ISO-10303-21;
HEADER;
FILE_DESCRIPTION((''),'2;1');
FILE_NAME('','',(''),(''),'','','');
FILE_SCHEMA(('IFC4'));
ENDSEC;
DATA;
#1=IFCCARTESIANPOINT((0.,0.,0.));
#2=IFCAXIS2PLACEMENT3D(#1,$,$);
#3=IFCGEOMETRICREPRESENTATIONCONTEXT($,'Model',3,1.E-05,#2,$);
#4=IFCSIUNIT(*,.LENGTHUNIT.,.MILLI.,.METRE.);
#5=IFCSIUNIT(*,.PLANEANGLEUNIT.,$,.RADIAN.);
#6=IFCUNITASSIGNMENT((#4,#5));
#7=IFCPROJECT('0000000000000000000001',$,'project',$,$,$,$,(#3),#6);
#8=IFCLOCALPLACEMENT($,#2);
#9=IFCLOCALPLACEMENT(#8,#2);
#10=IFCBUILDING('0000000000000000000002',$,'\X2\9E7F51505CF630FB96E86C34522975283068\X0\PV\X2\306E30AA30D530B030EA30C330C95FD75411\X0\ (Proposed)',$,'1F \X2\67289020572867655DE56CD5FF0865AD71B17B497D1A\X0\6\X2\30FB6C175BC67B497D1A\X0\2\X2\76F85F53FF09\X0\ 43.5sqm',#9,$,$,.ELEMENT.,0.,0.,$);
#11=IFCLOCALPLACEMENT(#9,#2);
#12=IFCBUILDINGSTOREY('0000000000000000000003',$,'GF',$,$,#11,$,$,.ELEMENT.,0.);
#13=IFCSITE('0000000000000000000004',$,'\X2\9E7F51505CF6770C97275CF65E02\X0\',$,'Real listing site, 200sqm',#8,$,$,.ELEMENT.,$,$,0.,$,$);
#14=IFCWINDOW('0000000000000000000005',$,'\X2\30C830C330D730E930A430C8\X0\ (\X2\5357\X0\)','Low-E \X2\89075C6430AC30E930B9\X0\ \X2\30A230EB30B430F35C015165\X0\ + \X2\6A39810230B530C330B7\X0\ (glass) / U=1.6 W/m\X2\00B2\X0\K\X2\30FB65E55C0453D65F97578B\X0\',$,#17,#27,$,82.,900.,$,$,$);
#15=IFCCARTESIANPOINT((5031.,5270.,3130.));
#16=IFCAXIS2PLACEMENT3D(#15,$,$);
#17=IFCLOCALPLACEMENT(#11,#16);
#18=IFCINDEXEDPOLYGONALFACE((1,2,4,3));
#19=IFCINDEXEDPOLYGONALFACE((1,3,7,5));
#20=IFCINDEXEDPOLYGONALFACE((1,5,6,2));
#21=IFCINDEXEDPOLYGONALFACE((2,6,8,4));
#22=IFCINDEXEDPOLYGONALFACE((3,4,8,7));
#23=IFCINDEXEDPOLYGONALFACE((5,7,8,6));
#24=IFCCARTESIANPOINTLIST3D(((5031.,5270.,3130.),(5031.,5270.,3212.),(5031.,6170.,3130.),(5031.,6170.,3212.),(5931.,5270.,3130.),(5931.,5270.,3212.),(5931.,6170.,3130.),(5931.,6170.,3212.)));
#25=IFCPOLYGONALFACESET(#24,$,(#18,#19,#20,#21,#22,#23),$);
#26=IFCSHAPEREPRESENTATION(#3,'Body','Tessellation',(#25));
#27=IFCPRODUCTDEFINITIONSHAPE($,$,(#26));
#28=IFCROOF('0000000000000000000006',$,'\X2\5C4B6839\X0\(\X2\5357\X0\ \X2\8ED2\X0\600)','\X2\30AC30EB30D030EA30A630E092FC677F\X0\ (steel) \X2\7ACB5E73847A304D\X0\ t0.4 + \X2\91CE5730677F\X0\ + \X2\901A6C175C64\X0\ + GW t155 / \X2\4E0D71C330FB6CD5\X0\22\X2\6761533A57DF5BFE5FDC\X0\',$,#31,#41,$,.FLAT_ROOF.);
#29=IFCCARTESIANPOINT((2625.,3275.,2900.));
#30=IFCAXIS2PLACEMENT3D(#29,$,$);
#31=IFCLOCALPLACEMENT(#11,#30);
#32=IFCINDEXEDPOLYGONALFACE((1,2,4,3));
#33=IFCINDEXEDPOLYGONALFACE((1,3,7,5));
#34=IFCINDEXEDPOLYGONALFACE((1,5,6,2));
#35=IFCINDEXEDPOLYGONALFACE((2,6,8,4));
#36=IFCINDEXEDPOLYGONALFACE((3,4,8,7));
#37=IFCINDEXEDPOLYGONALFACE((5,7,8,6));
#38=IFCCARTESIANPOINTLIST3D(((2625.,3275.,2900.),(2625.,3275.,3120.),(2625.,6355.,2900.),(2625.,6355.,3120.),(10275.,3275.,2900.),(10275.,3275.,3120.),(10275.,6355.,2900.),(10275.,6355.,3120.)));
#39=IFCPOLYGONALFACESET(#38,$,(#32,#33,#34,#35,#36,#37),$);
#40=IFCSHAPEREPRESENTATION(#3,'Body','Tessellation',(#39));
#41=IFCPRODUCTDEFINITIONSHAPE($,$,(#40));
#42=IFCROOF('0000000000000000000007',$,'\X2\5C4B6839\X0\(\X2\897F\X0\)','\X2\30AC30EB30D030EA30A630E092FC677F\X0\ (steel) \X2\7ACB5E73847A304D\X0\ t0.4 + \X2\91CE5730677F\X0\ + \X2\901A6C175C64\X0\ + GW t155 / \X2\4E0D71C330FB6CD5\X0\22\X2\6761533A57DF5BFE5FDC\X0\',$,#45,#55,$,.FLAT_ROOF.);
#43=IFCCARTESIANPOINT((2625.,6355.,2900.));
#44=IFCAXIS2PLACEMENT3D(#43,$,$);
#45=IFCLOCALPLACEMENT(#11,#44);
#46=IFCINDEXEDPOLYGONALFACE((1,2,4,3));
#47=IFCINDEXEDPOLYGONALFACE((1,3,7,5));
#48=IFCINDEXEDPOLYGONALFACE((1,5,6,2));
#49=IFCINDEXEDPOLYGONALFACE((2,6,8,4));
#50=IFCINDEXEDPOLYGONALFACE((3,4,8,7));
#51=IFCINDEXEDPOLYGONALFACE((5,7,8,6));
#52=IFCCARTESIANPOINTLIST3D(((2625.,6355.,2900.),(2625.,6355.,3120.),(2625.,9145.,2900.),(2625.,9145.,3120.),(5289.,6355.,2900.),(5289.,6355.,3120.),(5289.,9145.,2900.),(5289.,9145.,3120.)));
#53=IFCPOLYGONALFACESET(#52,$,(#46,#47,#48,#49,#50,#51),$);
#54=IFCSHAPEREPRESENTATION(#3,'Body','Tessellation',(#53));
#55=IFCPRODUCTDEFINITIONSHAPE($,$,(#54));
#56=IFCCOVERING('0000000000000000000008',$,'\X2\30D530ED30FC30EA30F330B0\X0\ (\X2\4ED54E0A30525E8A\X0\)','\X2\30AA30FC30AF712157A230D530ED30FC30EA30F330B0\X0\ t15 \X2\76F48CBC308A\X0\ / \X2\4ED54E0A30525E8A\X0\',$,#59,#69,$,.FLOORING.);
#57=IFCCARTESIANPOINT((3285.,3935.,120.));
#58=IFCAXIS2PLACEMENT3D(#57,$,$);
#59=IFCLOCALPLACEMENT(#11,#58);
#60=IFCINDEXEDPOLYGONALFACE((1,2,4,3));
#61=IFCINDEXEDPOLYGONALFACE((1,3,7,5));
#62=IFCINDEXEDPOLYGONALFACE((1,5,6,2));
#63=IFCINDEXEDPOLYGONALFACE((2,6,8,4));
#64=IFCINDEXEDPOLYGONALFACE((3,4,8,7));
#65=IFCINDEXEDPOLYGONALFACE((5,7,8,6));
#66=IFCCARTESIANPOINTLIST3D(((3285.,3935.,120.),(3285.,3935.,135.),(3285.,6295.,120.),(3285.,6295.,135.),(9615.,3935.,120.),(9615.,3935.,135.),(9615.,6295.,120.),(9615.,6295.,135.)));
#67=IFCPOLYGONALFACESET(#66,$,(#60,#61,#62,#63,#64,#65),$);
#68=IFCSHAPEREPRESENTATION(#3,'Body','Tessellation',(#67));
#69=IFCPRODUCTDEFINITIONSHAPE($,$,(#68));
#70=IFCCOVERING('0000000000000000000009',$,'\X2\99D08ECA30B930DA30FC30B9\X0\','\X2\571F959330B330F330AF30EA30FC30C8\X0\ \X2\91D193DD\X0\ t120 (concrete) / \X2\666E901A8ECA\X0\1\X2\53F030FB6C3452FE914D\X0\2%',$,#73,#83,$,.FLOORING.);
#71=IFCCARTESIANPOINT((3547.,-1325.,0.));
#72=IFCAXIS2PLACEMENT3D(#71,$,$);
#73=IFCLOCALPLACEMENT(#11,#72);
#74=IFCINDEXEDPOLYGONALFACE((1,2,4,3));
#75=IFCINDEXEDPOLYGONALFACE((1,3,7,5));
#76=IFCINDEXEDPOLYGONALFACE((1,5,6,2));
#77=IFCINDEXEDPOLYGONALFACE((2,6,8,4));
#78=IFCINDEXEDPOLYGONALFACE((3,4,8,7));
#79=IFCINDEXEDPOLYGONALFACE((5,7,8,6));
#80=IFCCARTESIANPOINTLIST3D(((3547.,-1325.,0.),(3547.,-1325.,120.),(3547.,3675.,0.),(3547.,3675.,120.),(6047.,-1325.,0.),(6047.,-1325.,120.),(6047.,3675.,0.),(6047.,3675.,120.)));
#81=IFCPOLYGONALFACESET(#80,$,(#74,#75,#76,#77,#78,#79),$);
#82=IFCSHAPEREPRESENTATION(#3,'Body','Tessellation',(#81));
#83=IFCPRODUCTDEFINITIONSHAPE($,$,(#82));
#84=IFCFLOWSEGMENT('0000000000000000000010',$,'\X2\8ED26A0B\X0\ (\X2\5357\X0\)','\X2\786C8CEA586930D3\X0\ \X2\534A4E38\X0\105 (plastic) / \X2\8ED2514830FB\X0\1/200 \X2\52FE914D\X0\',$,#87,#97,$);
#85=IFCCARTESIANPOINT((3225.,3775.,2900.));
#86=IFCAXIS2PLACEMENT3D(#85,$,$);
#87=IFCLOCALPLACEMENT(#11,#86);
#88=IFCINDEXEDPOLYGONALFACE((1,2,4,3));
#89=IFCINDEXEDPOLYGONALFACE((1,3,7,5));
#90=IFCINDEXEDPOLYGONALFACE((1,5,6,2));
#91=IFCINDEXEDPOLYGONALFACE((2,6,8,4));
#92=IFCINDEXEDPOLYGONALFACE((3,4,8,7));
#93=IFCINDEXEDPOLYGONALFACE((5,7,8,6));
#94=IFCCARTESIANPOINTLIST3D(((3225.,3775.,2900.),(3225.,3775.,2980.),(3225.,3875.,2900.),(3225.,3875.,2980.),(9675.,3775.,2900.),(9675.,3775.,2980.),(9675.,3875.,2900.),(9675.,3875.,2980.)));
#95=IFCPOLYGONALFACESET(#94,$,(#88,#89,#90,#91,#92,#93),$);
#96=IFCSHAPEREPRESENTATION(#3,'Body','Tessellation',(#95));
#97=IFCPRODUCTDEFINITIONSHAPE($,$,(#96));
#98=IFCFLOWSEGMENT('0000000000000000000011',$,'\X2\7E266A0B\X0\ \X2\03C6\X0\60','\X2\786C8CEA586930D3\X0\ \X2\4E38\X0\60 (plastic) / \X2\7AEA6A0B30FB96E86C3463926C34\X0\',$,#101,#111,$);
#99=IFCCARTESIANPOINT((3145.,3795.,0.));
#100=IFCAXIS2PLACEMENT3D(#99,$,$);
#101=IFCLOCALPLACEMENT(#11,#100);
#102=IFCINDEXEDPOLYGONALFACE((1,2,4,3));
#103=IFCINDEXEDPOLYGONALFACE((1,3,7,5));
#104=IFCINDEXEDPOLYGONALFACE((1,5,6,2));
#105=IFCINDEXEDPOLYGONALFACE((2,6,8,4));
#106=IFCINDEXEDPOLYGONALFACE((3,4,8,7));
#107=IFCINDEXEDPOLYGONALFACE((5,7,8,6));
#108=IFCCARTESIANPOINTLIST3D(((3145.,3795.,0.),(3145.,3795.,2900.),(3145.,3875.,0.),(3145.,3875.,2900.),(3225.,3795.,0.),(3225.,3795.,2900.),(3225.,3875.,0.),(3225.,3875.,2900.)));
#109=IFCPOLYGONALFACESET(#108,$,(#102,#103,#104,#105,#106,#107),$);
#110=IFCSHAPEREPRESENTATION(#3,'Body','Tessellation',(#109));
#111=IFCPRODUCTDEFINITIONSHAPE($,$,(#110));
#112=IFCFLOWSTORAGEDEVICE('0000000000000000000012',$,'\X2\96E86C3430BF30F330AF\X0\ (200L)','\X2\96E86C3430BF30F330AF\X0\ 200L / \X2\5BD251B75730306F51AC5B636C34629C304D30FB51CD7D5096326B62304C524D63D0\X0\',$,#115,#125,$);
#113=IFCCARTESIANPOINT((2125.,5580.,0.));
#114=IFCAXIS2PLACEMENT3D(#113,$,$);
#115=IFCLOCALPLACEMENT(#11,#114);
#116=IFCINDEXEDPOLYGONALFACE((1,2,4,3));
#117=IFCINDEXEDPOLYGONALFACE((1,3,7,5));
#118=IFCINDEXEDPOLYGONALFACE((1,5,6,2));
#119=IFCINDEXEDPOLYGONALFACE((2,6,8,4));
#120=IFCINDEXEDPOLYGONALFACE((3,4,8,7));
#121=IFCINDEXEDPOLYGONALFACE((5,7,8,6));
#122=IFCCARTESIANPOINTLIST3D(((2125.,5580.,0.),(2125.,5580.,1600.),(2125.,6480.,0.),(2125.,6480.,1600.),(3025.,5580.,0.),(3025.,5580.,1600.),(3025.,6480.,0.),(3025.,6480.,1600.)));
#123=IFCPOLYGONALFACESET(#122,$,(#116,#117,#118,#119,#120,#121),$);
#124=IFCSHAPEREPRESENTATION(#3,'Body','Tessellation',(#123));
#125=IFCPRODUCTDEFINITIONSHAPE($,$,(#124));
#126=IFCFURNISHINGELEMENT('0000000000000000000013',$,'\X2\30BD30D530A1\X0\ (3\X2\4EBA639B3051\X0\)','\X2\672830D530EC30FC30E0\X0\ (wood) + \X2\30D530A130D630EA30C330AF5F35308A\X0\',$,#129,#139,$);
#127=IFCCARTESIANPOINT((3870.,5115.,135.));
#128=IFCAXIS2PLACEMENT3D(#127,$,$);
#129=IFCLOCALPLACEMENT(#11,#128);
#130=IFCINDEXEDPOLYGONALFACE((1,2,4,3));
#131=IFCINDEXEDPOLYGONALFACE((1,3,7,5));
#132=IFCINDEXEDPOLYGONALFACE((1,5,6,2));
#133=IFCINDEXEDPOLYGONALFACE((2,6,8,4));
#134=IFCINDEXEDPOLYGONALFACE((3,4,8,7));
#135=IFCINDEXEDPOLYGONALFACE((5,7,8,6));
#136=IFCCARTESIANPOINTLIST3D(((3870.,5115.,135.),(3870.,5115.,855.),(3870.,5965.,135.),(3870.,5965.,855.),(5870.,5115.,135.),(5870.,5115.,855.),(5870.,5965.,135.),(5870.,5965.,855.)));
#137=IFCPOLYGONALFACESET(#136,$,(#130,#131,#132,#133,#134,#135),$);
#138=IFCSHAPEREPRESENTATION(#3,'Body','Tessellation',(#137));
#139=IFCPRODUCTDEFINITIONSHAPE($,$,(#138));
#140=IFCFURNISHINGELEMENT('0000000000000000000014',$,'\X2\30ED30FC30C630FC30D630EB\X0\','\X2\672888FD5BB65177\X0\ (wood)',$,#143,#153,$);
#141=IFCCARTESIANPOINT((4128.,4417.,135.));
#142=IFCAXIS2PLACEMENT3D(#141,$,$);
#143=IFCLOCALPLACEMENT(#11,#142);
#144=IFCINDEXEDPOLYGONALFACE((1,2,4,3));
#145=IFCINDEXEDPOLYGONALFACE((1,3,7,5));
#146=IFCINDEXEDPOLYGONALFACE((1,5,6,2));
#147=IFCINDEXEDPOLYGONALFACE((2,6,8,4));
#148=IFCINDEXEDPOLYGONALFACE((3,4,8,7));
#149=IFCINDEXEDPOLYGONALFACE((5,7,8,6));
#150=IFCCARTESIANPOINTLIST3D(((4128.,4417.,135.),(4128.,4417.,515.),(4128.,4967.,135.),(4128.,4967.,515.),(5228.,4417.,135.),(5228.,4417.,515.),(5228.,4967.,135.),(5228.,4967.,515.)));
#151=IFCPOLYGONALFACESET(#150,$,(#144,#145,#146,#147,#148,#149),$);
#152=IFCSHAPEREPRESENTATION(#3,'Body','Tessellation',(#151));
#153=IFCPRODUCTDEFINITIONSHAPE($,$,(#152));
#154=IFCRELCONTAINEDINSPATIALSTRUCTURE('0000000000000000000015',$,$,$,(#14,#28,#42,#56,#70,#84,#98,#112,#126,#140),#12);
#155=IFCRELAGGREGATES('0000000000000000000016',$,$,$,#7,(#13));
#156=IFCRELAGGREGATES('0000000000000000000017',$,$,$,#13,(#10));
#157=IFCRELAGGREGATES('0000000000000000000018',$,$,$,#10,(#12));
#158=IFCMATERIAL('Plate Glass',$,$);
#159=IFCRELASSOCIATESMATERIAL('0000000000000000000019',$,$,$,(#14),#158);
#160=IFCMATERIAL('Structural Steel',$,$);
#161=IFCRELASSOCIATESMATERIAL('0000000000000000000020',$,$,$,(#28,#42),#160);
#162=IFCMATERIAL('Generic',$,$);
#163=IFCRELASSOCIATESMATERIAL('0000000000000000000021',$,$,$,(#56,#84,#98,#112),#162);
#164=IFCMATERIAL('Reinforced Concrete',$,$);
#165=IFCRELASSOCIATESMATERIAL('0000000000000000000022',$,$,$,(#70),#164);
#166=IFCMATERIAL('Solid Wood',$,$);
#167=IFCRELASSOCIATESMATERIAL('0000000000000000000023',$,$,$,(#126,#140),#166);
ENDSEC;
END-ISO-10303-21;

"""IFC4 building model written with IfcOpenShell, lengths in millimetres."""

from ifc_helpers import new_model, si_unit, frame, frame_2d, origin, place, context, project, spatial, rectangle, extrude, material, element, save


model = new_model("IFC4")

# Units and contexts
model_context = context("Model", 3, precision=1e-05, world=origin())
ifc_project = project(units=[si_unit("LENGTHUNIT", "METRE", prefix="MILLI"), si_unit("PLANEANGLEUNIT", "RADIAN")], contexts=[model_context])

# Site, building, storey
site_placement = place(None, origin())
site = spatial("IfcSite", under=ifc_project, at=site_placement, Name="鹿児島県霧島市", ObjectType="Real listing site, 200sqm", CompositionType="ELEMENT", RefElevation=0.0)
building_placement = place(site_placement, origin())
building = spatial("IfcBuilding", under=site, at=building_placement, Name="鹿児島・雨水利用とPVのオフグリッド志向 (Proposed)", ObjectType="1F 木造在来工法（断熱等級6・気密等級2相当） 43.5sqm", CompositionType="ELEMENT", ElevationOfRefHeight=0.0, ElevationOfTerrain=0.0)
storey_placement = place(building_placement, origin())
storey = spatial("IfcBuildingStorey", under=building, at=storey_placement, Name="GF", CompositionType="ELEMENT", Elevation=0.0)

# Shared definitions
ifc_material_1 = material(Name="Solid Wood")

# Shared definitions
ifc_material_2 = material(Name="Reinforced Concrete")

# Shared definitions
ifc_material_3 = material(Name="Plate Glass")

# Window
window_1_placement = place(storey_placement, frame((5031.0, 5270.0, 3130.0)))
element("IfcWindow", 1, at=window_1_placement, inside=storey, material=ifc_material_3, Name="トップライト (南)", Description="Low-E 複層ガラス アルゴン封入 + 樹脂サッシ (glass) / U=1.6 W/m²K・日射取得型", OverallHeight=82.0, OverallWidth=900.0, context=model_context, shape_type="SweptSolid", body=[
    extrude(rectangle(XDim=900.0, YDim=900.0, at=frame_2d((450.0, 450.0))), frame((5031.0, 5270.0, 3130.0)), (0.0, 0.0, 1.0), 82.0),
])

# Roofs
ifc_material_4 = material(Name="Structural Steel")
roof_1_placement = place(storey_placement, frame((2625.0, 3275.0, 2900.0)))
element("IfcRoof", 2, at=roof_1_placement, inside=storey, material=ifc_material_4, Name="屋根(南 軒600)", Description="ガルバリウム鋼板 (steel) 立平葺き t0.4 + 野地板 + 通気層 + GW t155 / 不燃・法22条区域対応", PredefinedType="FLAT_ROOF", context=model_context, shape_type="SweptSolid", body=[
    extrude(rectangle(XDim=7650.0, YDim=3080.0, at=frame_2d((3825.0, 1540.0))), frame((2625.0, 3275.0, 2900.0)), (0.0, 0.0, 1.0), 220.0),
])
roof_2_placement = place(storey_placement, frame((2625.0, 6355.0, 2900.0)))
element("IfcRoof", 3, at=roof_2_placement, inside=storey, material=ifc_material_4, Name="屋根(西)", Description="ガルバリウム鋼板 (steel) 立平葺き t0.4 + 野地板 + 通気層 + GW t155 / 不燃・法22条区域対応", PredefinedType="FLAT_ROOF", context=model_context, shape_type="SweptSolid", body=[
    extrude(rectangle(XDim=2664.0, YDim=2790.0, at=frame_2d((1332.0, 1395.0))), frame((2625.0, 6355.0, 2900.0)), (0.0, 0.0, 1.0), 220.0),
])

# Coverings
ifc_material_5 = material(Name="Generic")
covering_1_placement = place(storey_placement, frame((3285.0, 3935.0, 120.0)))
element("IfcCovering", 4, at=covering_1_placement, inside=storey, material=ifc_material_5, Name="フローリング (仕上げ床)", Description="オーク無垢フローリング t15 直貼り / 仕上げ床", PredefinedType="FLOORING", context=model_context, shape_type="SweptSolid", body=[
    extrude(rectangle(XDim=6330.0, YDim=2360.0, at=frame_2d((3165.0, 1180.0))), frame((3285.0, 3935.0, 120.0)), (0.0, 0.0, 1.0), 15.0),
])
covering_2_placement = place(storey_placement, frame((3547.0, -1325.0, 0.0)))
element("IfcCovering", 5, at=covering_2_placement, inside=storey, material=ifc_material_2, Name="駐車スペース", Description="土間コンクリート 金鏝 t120 (concrete) / 普通車1台・水勾配2%", PredefinedType="FLOORING", context=model_context, shape_type="SweptSolid", body=[
    extrude(rectangle(XDim=2500.0, YDim=5000.0, at=frame_2d((1250.0, 2500.0))), frame((3547.0, -1325.0, 0.0)), (0.0, 0.0, 1.0), 120.0),
])

# Flow segments
flow_segment_1_placement = place(storey_placement, frame((3225.0, 3775.0, 2900.0)))
element("IfcFlowSegment", 6, at=flow_segment_1_placement, inside=storey, material=ifc_material_5, Name="軒樋 (南)", Description="硬質塩ビ 半丸105 (plastic) / 軒先・1/200 勾配", context=model_context, shape_type="SweptSolid", body=[
    extrude(rectangle(XDim=6450.0, YDim=100.0, at=frame_2d((3225.0, 50.0))), frame((3225.0, 3775.0, 2900.0)), (0.0, 0.0, 1.0), 80.0),
])
flow_segment_2_placement = place(storey_placement, frame((3145.0, 3795.0, 0.0)))
element("IfcFlowSegment", 7, at=flow_segment_2_placement, inside=storey, material=ifc_material_5, Name="縦樋 φ60", Description="硬質塩ビ 丸60 (plastic) / 竪樋・雨水排水", context=model_context, shape_type="SweptSolid", body=[
    extrude(rectangle(XDim=80.0, YDim=80.0, at=frame_2d((40.0, 40.0))), frame((3145.0, 3795.0, 0.0)), (0.0, 0.0, 1.0), 2900.0),
])

# Flow storage device
flow_storage_device_placement = place(storey_placement, frame((2125.0, 5580.0, 0.0)))
element("IfcFlowStorageDevice", 8, at=flow_storage_device_placement, inside=storey, material=ifc_material_5, Name="雨水タンク (200L)", Description="雨水タンク 200L / 寒冷地は冬季水抜き・凍結防止が前提", context=model_context, shape_type="SweptSolid", body=[
    extrude(rectangle(XDim=900.0, YDim=900.0, at=frame_2d((450.0, 450.0))), frame((2125.0, 5580.0, 0.0)), (0.0, 0.0, 1.0), 1600.0),
])

# Furnishing elements
furnishing_1_placement = place(storey_placement, frame((3870.0, 5115.0, 135.0)))
element("IfcFurnishingElement", 9, at=furnishing_1_placement, inside=storey, material=ifc_material_1, Name="ソファ (3人掛け)", Description="木フレーム (wood) + ファブリック張り", context=model_context, shape_type="SweptSolid", body=[
    extrude(rectangle(XDim=2000.0, YDim=850.0, at=frame_2d((1000.0, 425.0))), frame((3870.0, 5115.0, 135.0)), (0.0, 0.0, 1.0), 720.0),
])
furnishing_2_placement = place(storey_placement, frame((4128.0, 4417.0, 135.0)))
element("IfcFurnishingElement", 10, at=furnishing_2_placement, inside=storey, material=ifc_material_1, Name="ローテーブル", Description="木製家具 (wood)", context=model_context, shape_type="SweptSolid", body=[
    extrude(rectangle(XDim=1100.0, YDim=550.0, at=frame_2d((550.0, 275.0))), frame((4128.0, 4417.0, 135.0)), (0.0, 0.0, 1.0), 380.0),
])

save(model, "model.ifc")
